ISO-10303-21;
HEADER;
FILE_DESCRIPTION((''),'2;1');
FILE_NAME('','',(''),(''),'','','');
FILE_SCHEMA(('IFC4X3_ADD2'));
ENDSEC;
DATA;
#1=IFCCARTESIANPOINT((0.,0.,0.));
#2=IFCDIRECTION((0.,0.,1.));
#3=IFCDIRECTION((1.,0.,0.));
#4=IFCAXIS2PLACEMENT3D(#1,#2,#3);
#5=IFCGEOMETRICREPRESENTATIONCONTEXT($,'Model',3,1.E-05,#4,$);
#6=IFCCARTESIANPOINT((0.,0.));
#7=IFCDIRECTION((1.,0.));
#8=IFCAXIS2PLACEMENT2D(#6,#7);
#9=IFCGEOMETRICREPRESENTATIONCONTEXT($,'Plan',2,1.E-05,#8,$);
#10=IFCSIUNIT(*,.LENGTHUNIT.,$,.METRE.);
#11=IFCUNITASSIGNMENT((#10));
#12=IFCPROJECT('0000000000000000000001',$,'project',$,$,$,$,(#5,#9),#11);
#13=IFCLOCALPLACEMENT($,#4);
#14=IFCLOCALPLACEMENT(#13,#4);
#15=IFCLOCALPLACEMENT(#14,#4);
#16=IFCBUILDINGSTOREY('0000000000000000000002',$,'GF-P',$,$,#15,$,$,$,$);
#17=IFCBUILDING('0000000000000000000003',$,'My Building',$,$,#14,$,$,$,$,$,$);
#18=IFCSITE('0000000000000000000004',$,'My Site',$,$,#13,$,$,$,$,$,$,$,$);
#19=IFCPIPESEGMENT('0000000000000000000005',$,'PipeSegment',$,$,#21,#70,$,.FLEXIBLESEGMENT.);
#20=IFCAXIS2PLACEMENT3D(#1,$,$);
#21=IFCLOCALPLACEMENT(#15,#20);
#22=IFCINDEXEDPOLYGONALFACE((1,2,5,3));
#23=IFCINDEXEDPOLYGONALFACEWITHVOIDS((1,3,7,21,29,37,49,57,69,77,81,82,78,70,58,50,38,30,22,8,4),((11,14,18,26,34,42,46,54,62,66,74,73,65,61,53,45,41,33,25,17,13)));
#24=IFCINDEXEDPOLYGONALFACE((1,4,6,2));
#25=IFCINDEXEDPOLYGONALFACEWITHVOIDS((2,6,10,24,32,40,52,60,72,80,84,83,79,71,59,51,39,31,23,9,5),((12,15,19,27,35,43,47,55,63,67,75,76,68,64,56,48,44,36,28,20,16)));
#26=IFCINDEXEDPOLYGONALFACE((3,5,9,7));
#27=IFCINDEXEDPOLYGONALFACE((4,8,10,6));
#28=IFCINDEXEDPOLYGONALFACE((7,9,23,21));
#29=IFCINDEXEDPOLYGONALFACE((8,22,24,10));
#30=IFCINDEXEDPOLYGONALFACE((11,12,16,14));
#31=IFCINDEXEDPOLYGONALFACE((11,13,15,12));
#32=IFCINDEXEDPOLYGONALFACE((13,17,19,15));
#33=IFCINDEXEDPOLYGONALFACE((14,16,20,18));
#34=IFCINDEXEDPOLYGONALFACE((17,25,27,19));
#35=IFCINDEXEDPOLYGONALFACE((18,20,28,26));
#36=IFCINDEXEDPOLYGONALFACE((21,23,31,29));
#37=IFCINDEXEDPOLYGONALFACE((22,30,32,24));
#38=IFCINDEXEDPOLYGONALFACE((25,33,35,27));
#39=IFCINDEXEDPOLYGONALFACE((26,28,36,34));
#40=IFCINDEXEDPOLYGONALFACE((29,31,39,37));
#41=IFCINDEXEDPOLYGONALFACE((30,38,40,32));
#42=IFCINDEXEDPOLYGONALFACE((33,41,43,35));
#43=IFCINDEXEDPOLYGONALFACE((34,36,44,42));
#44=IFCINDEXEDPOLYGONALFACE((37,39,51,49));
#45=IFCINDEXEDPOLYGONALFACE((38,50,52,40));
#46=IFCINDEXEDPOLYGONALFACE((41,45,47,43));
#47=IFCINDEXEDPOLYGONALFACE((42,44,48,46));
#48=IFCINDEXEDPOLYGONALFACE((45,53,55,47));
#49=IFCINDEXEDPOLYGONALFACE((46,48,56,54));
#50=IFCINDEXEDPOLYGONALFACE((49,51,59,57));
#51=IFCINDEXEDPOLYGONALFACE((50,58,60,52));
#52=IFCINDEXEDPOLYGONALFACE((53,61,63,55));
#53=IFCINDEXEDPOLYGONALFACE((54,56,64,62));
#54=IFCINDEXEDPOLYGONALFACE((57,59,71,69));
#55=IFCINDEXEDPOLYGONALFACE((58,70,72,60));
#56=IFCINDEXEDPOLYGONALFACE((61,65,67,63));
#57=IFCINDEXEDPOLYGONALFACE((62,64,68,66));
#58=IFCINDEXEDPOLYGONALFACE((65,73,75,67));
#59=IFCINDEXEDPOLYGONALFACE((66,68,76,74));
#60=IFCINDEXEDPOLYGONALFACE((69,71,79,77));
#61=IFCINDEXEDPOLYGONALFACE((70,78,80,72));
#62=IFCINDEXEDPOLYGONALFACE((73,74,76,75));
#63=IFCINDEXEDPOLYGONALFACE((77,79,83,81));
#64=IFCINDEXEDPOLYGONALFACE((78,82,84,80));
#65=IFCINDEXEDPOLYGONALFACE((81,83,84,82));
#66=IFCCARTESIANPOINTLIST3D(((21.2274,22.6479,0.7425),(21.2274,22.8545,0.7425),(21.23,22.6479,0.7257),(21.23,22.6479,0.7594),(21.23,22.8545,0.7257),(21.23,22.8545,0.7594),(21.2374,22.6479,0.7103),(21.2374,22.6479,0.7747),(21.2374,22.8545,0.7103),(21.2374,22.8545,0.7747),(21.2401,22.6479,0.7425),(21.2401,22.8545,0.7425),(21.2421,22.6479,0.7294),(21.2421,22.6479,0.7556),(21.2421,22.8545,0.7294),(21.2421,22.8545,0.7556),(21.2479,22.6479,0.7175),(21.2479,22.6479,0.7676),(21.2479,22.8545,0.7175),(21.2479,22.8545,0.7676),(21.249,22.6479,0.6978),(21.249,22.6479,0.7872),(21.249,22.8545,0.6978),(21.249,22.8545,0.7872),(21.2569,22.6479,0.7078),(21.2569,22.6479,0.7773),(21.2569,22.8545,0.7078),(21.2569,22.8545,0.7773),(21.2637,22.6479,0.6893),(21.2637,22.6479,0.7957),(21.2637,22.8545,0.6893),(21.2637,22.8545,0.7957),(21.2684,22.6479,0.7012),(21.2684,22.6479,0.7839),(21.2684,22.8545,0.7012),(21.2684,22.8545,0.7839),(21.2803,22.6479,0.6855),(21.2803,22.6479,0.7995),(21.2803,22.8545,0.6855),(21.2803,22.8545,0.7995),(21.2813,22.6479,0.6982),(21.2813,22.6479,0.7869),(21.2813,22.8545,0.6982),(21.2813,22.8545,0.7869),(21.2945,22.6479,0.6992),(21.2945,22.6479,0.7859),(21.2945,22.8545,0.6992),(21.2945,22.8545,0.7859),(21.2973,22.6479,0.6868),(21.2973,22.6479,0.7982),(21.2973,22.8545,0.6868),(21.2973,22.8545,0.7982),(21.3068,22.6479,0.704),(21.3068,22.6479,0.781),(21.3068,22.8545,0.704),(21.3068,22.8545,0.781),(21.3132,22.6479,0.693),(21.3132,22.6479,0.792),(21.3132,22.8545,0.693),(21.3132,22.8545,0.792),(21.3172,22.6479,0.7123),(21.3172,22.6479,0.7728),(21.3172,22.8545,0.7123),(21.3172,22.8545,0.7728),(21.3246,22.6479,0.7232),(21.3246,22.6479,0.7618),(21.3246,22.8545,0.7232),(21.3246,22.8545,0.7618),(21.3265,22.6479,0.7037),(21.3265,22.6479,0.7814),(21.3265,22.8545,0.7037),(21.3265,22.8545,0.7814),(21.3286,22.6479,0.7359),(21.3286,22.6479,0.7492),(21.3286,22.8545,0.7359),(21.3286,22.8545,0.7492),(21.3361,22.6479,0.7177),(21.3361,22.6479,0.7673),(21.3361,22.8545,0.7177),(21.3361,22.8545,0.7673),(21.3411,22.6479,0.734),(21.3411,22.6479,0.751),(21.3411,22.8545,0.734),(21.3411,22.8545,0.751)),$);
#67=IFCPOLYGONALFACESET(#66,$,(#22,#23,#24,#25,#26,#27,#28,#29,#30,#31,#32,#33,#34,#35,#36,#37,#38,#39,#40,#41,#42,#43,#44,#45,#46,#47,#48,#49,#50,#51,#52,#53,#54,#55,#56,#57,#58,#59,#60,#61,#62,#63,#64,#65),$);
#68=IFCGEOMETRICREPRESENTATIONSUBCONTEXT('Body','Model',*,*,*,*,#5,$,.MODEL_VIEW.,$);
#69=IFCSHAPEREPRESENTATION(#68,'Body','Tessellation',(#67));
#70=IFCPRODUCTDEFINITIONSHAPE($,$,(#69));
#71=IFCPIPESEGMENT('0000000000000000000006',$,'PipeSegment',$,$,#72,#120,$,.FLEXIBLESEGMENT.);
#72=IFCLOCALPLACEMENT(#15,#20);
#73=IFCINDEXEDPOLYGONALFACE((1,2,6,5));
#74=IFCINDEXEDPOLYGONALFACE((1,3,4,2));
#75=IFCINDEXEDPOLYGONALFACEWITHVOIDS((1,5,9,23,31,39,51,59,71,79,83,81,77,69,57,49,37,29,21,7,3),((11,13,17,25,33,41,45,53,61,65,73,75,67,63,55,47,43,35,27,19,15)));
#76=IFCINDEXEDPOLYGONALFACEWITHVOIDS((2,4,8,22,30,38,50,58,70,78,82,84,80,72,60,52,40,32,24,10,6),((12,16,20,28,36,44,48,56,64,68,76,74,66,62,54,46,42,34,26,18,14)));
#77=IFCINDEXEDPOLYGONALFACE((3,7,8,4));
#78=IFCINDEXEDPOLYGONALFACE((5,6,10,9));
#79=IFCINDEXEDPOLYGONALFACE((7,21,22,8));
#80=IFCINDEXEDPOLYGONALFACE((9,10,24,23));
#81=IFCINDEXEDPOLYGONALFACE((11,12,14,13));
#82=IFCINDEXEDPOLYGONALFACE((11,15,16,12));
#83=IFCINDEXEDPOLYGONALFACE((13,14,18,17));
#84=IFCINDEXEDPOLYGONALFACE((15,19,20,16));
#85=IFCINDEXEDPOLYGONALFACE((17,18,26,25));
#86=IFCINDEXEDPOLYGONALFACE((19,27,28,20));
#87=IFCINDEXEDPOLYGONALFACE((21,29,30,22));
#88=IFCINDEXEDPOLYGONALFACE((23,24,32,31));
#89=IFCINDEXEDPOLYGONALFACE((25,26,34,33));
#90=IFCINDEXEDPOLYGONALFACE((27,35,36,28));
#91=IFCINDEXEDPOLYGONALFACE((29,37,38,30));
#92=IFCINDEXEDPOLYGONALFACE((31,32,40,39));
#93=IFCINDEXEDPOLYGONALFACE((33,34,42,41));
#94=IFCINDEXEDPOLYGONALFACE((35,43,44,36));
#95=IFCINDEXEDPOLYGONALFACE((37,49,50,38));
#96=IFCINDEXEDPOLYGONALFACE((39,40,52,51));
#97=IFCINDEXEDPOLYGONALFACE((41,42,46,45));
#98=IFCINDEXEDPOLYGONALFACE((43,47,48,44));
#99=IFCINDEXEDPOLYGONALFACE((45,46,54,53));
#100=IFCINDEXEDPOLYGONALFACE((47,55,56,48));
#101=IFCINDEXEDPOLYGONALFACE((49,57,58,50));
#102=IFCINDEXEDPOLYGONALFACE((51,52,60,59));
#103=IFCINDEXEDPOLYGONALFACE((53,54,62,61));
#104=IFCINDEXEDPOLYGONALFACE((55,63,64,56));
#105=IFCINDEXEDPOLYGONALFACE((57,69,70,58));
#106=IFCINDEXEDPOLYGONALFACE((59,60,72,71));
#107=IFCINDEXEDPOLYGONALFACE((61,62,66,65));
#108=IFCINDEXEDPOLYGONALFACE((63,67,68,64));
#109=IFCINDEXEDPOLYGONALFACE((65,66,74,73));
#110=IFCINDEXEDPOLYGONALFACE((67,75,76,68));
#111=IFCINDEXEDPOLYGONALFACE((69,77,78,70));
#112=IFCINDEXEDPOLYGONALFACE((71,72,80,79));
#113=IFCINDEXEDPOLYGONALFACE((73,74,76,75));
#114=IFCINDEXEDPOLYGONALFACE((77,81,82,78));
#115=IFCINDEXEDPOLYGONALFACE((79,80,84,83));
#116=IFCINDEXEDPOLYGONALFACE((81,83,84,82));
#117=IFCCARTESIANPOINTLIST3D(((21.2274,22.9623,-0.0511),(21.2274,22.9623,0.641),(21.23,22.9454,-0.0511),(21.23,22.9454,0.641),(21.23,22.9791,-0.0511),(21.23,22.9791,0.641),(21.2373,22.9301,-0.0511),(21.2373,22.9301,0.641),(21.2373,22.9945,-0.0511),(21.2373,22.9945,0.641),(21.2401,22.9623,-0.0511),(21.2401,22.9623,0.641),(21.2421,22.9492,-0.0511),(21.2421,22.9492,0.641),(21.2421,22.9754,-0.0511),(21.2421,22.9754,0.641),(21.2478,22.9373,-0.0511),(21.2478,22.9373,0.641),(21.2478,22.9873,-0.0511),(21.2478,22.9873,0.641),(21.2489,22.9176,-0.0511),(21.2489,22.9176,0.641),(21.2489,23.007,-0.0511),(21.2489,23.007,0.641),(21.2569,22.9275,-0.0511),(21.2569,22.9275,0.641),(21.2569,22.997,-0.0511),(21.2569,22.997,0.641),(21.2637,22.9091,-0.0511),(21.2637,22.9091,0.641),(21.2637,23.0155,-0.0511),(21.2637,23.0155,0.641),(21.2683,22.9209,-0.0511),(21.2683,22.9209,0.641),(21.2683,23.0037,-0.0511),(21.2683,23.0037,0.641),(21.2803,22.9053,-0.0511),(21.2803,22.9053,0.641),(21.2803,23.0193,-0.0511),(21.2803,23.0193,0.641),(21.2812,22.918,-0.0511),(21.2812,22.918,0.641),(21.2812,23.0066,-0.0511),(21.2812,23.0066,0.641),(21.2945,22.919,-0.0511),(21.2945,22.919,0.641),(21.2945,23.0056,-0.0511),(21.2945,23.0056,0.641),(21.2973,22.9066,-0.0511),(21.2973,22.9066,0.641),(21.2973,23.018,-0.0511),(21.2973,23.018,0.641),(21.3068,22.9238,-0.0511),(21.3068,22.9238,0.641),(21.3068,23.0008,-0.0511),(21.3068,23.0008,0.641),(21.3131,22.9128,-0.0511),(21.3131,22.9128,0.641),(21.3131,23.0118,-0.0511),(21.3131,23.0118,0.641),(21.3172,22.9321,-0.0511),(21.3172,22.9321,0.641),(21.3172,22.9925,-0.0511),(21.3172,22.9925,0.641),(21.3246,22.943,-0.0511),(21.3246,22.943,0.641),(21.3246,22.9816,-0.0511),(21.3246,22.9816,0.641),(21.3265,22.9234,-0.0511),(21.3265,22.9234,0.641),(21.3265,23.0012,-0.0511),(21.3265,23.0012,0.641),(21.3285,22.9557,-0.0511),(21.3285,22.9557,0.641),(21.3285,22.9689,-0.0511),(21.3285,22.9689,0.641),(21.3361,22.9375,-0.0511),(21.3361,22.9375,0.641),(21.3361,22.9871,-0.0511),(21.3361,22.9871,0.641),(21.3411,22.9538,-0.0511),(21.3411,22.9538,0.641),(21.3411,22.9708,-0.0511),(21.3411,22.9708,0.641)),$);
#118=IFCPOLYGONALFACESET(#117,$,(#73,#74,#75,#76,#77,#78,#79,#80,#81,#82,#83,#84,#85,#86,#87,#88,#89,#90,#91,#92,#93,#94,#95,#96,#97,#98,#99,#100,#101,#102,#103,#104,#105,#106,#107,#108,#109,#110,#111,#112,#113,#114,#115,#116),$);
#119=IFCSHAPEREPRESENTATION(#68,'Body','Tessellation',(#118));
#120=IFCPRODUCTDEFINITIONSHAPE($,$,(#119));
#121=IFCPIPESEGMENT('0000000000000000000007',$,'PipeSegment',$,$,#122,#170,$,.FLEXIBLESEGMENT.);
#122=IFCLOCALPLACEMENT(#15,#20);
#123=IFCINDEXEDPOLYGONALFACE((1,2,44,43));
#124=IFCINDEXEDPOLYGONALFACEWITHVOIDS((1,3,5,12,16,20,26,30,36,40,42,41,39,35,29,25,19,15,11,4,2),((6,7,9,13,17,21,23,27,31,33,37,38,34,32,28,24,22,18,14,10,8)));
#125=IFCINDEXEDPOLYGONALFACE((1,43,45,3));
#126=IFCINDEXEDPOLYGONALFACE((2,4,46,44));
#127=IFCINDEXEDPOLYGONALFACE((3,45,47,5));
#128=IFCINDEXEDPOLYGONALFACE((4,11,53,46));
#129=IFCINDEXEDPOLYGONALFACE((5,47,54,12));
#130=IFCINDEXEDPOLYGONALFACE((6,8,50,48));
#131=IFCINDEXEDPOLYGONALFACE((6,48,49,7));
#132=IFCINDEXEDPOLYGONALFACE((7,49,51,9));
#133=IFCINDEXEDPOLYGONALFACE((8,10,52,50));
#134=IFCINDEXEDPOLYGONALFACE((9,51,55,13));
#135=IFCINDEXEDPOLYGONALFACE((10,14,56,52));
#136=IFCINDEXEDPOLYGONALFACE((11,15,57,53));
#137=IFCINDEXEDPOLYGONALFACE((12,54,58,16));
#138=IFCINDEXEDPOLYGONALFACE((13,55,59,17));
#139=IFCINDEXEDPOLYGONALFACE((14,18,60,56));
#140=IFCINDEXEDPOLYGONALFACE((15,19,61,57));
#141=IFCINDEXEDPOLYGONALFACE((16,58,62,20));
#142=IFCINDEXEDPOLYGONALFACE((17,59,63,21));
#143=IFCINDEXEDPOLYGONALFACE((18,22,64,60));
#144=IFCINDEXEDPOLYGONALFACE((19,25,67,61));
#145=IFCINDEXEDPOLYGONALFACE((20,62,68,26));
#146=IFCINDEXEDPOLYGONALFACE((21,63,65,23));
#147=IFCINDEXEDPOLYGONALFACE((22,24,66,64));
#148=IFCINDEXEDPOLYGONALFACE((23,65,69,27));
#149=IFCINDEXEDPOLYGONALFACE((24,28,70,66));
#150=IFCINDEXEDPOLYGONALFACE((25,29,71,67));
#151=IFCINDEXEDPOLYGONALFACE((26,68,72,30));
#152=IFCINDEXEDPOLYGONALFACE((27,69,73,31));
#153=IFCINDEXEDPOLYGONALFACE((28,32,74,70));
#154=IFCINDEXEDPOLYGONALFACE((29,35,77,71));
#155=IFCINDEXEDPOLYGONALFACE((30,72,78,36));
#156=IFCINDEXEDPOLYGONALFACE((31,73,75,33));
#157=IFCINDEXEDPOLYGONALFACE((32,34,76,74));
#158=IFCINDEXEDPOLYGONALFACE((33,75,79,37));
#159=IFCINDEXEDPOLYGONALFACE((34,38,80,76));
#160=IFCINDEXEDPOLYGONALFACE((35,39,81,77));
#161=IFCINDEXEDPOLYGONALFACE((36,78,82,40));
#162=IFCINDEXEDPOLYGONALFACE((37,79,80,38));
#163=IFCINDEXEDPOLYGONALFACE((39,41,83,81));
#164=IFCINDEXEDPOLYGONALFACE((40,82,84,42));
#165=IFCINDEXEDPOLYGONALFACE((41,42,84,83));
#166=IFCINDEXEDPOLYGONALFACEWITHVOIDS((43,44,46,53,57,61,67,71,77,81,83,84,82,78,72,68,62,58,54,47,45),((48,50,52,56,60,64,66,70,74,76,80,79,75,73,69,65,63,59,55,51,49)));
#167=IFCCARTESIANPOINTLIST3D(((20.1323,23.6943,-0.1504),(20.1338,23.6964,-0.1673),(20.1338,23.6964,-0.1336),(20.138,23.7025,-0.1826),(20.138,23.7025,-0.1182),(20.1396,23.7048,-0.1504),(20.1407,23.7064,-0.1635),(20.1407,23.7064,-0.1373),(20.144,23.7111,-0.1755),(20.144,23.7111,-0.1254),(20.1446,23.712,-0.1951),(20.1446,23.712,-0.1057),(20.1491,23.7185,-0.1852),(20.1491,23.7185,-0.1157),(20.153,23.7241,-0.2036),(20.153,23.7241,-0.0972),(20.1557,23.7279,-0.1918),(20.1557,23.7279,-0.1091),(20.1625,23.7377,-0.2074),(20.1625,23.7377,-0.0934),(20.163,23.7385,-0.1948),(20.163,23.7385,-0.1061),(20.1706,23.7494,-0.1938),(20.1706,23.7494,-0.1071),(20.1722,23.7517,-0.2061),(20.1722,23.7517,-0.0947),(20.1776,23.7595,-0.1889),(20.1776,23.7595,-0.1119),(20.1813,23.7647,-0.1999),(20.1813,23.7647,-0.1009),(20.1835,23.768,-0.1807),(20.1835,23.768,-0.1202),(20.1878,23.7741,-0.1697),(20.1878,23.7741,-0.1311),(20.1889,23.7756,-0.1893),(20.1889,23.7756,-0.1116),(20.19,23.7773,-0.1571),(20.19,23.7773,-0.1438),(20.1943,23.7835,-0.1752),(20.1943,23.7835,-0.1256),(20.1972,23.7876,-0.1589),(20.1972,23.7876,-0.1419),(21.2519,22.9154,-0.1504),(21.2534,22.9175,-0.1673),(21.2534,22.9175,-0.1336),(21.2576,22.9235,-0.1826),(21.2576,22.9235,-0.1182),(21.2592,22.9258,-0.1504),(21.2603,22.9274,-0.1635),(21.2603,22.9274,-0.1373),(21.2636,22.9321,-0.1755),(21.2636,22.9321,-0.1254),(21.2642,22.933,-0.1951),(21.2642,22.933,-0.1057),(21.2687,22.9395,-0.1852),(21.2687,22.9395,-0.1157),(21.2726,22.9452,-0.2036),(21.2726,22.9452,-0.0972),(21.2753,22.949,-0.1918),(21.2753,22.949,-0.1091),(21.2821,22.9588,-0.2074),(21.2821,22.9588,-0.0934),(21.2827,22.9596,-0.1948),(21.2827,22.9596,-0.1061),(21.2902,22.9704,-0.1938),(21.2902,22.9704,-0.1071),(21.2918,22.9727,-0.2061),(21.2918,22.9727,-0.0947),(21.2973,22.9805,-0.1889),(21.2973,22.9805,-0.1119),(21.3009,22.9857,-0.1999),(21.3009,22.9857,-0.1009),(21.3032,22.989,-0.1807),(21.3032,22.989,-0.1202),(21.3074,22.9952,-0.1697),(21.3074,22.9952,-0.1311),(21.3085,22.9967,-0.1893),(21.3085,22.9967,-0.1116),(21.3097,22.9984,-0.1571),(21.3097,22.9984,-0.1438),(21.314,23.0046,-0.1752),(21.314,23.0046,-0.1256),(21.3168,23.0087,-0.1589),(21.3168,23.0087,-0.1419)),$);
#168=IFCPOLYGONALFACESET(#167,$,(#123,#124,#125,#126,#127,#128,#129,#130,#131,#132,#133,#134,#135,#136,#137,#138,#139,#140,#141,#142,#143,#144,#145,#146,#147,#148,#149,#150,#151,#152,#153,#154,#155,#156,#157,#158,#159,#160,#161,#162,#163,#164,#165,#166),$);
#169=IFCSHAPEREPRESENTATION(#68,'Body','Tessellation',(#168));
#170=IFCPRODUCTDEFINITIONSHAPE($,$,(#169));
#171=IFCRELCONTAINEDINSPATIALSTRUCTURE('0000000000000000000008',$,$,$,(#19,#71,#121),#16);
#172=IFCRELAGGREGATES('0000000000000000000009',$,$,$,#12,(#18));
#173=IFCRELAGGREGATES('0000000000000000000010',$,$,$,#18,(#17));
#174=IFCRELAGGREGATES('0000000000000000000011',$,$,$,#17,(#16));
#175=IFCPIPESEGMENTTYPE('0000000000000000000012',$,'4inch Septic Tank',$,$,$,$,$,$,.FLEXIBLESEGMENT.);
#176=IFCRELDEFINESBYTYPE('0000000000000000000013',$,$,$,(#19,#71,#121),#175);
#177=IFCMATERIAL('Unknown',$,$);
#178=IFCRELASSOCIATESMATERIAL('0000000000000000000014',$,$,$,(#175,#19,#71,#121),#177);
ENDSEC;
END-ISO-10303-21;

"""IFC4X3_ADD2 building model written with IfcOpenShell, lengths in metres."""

from ifc_helpers import new_model, si_unit, frame, origin_with_axes, origin_2d_with_axis, place, context, subcontext, project, spatial, hollow_circle, extrude, material, material_profile, profile_set, profile_usage, type_object, element, save


model = new_model("IFC4X3_ADD2")

# Units and contexts
model_context = context("Model", 3, precision=1e-05, world=origin_with_axes())
plan_context = context("Plan", 2, precision=1e-05, world=origin_2d_with_axis())
body_context = subcontext(model_context, "Body", "Model", "MODEL_VIEW")
ifc_project = project(units=[si_unit("LENGTHUNIT", "METRE")], contexts=[model_context, plan_context])

# Site, building, storey
site_placement = place(None, origin_with_axes())
site = spatial("IfcSite", under=ifc_project, at=site_placement, Name="My Site")
building_placement = place(site_placement, origin_with_axes())
building = spatial("IfcBuilding", under=site, at=building_placement, Name="My Building")
storey_placement = place(building_placement, origin_with_axes())
storey = spatial("IfcBuildingStorey", under=building, at=storey_placement, Name="GF-P")

# Pipe segments
ifc_material_1 = material(Name="Unknown")
ifc_material_profile_1 = material_profile(ifc_material_1, hollow_circle(Radius=0.0571, WallThickness=0.0127))
ifc_profile_set_1 = profile_set([ifc_material_profile_1], Name="blackwater")
ifc_profile_usage_1 = profile_usage(ifc_profile_set_1, cardinal=5)
pipe_segment_type_1 = type_object("IfcPipeSegmentType", Name="4inch Septic Tank", PredefinedType="FLEXIBLESEGMENT", material=ifc_profile_set_1)
pipe_segment_1_placement = place(storey_placement, frame((21.2846, 22.6479, 0.7425), z_axis=(0.0, 1.0, 0.0), x_axis=(-1.0, 0.0, 0.0)))
element("IfcPipeSegment", 1, at=pipe_segment_1_placement, inside=storey, type_object=pipe_segment_type_1, material=ifc_profile_usage_1, Name="PipeSegment", PredefinedType="FLEXIBLESEGMENT", context=body_context, shape_type="SweptSolid", body=[
    extrude(hollow_circle(Radius=0.0571, WallThickness=0.0127), origin_with_axes(), (0.0, 0.0, 1.0), 0.2066),
])
ifc_profile_usage_2 = profile_usage(ifc_profile_set_1, cardinal=5)
pipe_segment_2_placement = place(storey_placement, frame((21.2846, 22.9623, -0.0511), z_axis=(0.0, 0.0, 1.0), x_axis=(-1.0, 0.0, 0.0)))
element("IfcPipeSegment", 2, at=pipe_segment_2_placement, inside=storey, type_object=pipe_segment_type_1, material=ifc_profile_usage_2, Name="PipeSegment", PredefinedType="FLEXIBLESEGMENT", context=body_context, shape_type="SweptSolid", body=[
    extrude(hollow_circle(Radius=0.0571, WallThickness=0.0127), origin_with_axes(), (0.0, 0.0, 1.0), 0.6922),
])
ifc_profile_usage_3 = profile_usage(ifc_profile_set_1, cardinal=5)
pipe_segment_3_placement = place(storey_placement, frame((21.2846, 22.9623, -0.1504), z_axis=(-0.820875, 0.571108, 0.0), x_axis=(-0.571108, -0.820875, 0.0)))
element("IfcPipeSegment", 3, at=pipe_segment_3_placement, inside=storey, type_object=pipe_segment_type_1, material=ifc_profile_usage_3, Name="PipeSegment", PredefinedType="FLEXIBLESEGMENT", context=body_context, shape_type="SweptSolid", body=[
    extrude(hollow_circle(Radius=0.0571, WallThickness=0.0127), origin_with_axes(), (0.0, 0.0, 1.0), 1.3639),
])

save(model, "model.ifc")
